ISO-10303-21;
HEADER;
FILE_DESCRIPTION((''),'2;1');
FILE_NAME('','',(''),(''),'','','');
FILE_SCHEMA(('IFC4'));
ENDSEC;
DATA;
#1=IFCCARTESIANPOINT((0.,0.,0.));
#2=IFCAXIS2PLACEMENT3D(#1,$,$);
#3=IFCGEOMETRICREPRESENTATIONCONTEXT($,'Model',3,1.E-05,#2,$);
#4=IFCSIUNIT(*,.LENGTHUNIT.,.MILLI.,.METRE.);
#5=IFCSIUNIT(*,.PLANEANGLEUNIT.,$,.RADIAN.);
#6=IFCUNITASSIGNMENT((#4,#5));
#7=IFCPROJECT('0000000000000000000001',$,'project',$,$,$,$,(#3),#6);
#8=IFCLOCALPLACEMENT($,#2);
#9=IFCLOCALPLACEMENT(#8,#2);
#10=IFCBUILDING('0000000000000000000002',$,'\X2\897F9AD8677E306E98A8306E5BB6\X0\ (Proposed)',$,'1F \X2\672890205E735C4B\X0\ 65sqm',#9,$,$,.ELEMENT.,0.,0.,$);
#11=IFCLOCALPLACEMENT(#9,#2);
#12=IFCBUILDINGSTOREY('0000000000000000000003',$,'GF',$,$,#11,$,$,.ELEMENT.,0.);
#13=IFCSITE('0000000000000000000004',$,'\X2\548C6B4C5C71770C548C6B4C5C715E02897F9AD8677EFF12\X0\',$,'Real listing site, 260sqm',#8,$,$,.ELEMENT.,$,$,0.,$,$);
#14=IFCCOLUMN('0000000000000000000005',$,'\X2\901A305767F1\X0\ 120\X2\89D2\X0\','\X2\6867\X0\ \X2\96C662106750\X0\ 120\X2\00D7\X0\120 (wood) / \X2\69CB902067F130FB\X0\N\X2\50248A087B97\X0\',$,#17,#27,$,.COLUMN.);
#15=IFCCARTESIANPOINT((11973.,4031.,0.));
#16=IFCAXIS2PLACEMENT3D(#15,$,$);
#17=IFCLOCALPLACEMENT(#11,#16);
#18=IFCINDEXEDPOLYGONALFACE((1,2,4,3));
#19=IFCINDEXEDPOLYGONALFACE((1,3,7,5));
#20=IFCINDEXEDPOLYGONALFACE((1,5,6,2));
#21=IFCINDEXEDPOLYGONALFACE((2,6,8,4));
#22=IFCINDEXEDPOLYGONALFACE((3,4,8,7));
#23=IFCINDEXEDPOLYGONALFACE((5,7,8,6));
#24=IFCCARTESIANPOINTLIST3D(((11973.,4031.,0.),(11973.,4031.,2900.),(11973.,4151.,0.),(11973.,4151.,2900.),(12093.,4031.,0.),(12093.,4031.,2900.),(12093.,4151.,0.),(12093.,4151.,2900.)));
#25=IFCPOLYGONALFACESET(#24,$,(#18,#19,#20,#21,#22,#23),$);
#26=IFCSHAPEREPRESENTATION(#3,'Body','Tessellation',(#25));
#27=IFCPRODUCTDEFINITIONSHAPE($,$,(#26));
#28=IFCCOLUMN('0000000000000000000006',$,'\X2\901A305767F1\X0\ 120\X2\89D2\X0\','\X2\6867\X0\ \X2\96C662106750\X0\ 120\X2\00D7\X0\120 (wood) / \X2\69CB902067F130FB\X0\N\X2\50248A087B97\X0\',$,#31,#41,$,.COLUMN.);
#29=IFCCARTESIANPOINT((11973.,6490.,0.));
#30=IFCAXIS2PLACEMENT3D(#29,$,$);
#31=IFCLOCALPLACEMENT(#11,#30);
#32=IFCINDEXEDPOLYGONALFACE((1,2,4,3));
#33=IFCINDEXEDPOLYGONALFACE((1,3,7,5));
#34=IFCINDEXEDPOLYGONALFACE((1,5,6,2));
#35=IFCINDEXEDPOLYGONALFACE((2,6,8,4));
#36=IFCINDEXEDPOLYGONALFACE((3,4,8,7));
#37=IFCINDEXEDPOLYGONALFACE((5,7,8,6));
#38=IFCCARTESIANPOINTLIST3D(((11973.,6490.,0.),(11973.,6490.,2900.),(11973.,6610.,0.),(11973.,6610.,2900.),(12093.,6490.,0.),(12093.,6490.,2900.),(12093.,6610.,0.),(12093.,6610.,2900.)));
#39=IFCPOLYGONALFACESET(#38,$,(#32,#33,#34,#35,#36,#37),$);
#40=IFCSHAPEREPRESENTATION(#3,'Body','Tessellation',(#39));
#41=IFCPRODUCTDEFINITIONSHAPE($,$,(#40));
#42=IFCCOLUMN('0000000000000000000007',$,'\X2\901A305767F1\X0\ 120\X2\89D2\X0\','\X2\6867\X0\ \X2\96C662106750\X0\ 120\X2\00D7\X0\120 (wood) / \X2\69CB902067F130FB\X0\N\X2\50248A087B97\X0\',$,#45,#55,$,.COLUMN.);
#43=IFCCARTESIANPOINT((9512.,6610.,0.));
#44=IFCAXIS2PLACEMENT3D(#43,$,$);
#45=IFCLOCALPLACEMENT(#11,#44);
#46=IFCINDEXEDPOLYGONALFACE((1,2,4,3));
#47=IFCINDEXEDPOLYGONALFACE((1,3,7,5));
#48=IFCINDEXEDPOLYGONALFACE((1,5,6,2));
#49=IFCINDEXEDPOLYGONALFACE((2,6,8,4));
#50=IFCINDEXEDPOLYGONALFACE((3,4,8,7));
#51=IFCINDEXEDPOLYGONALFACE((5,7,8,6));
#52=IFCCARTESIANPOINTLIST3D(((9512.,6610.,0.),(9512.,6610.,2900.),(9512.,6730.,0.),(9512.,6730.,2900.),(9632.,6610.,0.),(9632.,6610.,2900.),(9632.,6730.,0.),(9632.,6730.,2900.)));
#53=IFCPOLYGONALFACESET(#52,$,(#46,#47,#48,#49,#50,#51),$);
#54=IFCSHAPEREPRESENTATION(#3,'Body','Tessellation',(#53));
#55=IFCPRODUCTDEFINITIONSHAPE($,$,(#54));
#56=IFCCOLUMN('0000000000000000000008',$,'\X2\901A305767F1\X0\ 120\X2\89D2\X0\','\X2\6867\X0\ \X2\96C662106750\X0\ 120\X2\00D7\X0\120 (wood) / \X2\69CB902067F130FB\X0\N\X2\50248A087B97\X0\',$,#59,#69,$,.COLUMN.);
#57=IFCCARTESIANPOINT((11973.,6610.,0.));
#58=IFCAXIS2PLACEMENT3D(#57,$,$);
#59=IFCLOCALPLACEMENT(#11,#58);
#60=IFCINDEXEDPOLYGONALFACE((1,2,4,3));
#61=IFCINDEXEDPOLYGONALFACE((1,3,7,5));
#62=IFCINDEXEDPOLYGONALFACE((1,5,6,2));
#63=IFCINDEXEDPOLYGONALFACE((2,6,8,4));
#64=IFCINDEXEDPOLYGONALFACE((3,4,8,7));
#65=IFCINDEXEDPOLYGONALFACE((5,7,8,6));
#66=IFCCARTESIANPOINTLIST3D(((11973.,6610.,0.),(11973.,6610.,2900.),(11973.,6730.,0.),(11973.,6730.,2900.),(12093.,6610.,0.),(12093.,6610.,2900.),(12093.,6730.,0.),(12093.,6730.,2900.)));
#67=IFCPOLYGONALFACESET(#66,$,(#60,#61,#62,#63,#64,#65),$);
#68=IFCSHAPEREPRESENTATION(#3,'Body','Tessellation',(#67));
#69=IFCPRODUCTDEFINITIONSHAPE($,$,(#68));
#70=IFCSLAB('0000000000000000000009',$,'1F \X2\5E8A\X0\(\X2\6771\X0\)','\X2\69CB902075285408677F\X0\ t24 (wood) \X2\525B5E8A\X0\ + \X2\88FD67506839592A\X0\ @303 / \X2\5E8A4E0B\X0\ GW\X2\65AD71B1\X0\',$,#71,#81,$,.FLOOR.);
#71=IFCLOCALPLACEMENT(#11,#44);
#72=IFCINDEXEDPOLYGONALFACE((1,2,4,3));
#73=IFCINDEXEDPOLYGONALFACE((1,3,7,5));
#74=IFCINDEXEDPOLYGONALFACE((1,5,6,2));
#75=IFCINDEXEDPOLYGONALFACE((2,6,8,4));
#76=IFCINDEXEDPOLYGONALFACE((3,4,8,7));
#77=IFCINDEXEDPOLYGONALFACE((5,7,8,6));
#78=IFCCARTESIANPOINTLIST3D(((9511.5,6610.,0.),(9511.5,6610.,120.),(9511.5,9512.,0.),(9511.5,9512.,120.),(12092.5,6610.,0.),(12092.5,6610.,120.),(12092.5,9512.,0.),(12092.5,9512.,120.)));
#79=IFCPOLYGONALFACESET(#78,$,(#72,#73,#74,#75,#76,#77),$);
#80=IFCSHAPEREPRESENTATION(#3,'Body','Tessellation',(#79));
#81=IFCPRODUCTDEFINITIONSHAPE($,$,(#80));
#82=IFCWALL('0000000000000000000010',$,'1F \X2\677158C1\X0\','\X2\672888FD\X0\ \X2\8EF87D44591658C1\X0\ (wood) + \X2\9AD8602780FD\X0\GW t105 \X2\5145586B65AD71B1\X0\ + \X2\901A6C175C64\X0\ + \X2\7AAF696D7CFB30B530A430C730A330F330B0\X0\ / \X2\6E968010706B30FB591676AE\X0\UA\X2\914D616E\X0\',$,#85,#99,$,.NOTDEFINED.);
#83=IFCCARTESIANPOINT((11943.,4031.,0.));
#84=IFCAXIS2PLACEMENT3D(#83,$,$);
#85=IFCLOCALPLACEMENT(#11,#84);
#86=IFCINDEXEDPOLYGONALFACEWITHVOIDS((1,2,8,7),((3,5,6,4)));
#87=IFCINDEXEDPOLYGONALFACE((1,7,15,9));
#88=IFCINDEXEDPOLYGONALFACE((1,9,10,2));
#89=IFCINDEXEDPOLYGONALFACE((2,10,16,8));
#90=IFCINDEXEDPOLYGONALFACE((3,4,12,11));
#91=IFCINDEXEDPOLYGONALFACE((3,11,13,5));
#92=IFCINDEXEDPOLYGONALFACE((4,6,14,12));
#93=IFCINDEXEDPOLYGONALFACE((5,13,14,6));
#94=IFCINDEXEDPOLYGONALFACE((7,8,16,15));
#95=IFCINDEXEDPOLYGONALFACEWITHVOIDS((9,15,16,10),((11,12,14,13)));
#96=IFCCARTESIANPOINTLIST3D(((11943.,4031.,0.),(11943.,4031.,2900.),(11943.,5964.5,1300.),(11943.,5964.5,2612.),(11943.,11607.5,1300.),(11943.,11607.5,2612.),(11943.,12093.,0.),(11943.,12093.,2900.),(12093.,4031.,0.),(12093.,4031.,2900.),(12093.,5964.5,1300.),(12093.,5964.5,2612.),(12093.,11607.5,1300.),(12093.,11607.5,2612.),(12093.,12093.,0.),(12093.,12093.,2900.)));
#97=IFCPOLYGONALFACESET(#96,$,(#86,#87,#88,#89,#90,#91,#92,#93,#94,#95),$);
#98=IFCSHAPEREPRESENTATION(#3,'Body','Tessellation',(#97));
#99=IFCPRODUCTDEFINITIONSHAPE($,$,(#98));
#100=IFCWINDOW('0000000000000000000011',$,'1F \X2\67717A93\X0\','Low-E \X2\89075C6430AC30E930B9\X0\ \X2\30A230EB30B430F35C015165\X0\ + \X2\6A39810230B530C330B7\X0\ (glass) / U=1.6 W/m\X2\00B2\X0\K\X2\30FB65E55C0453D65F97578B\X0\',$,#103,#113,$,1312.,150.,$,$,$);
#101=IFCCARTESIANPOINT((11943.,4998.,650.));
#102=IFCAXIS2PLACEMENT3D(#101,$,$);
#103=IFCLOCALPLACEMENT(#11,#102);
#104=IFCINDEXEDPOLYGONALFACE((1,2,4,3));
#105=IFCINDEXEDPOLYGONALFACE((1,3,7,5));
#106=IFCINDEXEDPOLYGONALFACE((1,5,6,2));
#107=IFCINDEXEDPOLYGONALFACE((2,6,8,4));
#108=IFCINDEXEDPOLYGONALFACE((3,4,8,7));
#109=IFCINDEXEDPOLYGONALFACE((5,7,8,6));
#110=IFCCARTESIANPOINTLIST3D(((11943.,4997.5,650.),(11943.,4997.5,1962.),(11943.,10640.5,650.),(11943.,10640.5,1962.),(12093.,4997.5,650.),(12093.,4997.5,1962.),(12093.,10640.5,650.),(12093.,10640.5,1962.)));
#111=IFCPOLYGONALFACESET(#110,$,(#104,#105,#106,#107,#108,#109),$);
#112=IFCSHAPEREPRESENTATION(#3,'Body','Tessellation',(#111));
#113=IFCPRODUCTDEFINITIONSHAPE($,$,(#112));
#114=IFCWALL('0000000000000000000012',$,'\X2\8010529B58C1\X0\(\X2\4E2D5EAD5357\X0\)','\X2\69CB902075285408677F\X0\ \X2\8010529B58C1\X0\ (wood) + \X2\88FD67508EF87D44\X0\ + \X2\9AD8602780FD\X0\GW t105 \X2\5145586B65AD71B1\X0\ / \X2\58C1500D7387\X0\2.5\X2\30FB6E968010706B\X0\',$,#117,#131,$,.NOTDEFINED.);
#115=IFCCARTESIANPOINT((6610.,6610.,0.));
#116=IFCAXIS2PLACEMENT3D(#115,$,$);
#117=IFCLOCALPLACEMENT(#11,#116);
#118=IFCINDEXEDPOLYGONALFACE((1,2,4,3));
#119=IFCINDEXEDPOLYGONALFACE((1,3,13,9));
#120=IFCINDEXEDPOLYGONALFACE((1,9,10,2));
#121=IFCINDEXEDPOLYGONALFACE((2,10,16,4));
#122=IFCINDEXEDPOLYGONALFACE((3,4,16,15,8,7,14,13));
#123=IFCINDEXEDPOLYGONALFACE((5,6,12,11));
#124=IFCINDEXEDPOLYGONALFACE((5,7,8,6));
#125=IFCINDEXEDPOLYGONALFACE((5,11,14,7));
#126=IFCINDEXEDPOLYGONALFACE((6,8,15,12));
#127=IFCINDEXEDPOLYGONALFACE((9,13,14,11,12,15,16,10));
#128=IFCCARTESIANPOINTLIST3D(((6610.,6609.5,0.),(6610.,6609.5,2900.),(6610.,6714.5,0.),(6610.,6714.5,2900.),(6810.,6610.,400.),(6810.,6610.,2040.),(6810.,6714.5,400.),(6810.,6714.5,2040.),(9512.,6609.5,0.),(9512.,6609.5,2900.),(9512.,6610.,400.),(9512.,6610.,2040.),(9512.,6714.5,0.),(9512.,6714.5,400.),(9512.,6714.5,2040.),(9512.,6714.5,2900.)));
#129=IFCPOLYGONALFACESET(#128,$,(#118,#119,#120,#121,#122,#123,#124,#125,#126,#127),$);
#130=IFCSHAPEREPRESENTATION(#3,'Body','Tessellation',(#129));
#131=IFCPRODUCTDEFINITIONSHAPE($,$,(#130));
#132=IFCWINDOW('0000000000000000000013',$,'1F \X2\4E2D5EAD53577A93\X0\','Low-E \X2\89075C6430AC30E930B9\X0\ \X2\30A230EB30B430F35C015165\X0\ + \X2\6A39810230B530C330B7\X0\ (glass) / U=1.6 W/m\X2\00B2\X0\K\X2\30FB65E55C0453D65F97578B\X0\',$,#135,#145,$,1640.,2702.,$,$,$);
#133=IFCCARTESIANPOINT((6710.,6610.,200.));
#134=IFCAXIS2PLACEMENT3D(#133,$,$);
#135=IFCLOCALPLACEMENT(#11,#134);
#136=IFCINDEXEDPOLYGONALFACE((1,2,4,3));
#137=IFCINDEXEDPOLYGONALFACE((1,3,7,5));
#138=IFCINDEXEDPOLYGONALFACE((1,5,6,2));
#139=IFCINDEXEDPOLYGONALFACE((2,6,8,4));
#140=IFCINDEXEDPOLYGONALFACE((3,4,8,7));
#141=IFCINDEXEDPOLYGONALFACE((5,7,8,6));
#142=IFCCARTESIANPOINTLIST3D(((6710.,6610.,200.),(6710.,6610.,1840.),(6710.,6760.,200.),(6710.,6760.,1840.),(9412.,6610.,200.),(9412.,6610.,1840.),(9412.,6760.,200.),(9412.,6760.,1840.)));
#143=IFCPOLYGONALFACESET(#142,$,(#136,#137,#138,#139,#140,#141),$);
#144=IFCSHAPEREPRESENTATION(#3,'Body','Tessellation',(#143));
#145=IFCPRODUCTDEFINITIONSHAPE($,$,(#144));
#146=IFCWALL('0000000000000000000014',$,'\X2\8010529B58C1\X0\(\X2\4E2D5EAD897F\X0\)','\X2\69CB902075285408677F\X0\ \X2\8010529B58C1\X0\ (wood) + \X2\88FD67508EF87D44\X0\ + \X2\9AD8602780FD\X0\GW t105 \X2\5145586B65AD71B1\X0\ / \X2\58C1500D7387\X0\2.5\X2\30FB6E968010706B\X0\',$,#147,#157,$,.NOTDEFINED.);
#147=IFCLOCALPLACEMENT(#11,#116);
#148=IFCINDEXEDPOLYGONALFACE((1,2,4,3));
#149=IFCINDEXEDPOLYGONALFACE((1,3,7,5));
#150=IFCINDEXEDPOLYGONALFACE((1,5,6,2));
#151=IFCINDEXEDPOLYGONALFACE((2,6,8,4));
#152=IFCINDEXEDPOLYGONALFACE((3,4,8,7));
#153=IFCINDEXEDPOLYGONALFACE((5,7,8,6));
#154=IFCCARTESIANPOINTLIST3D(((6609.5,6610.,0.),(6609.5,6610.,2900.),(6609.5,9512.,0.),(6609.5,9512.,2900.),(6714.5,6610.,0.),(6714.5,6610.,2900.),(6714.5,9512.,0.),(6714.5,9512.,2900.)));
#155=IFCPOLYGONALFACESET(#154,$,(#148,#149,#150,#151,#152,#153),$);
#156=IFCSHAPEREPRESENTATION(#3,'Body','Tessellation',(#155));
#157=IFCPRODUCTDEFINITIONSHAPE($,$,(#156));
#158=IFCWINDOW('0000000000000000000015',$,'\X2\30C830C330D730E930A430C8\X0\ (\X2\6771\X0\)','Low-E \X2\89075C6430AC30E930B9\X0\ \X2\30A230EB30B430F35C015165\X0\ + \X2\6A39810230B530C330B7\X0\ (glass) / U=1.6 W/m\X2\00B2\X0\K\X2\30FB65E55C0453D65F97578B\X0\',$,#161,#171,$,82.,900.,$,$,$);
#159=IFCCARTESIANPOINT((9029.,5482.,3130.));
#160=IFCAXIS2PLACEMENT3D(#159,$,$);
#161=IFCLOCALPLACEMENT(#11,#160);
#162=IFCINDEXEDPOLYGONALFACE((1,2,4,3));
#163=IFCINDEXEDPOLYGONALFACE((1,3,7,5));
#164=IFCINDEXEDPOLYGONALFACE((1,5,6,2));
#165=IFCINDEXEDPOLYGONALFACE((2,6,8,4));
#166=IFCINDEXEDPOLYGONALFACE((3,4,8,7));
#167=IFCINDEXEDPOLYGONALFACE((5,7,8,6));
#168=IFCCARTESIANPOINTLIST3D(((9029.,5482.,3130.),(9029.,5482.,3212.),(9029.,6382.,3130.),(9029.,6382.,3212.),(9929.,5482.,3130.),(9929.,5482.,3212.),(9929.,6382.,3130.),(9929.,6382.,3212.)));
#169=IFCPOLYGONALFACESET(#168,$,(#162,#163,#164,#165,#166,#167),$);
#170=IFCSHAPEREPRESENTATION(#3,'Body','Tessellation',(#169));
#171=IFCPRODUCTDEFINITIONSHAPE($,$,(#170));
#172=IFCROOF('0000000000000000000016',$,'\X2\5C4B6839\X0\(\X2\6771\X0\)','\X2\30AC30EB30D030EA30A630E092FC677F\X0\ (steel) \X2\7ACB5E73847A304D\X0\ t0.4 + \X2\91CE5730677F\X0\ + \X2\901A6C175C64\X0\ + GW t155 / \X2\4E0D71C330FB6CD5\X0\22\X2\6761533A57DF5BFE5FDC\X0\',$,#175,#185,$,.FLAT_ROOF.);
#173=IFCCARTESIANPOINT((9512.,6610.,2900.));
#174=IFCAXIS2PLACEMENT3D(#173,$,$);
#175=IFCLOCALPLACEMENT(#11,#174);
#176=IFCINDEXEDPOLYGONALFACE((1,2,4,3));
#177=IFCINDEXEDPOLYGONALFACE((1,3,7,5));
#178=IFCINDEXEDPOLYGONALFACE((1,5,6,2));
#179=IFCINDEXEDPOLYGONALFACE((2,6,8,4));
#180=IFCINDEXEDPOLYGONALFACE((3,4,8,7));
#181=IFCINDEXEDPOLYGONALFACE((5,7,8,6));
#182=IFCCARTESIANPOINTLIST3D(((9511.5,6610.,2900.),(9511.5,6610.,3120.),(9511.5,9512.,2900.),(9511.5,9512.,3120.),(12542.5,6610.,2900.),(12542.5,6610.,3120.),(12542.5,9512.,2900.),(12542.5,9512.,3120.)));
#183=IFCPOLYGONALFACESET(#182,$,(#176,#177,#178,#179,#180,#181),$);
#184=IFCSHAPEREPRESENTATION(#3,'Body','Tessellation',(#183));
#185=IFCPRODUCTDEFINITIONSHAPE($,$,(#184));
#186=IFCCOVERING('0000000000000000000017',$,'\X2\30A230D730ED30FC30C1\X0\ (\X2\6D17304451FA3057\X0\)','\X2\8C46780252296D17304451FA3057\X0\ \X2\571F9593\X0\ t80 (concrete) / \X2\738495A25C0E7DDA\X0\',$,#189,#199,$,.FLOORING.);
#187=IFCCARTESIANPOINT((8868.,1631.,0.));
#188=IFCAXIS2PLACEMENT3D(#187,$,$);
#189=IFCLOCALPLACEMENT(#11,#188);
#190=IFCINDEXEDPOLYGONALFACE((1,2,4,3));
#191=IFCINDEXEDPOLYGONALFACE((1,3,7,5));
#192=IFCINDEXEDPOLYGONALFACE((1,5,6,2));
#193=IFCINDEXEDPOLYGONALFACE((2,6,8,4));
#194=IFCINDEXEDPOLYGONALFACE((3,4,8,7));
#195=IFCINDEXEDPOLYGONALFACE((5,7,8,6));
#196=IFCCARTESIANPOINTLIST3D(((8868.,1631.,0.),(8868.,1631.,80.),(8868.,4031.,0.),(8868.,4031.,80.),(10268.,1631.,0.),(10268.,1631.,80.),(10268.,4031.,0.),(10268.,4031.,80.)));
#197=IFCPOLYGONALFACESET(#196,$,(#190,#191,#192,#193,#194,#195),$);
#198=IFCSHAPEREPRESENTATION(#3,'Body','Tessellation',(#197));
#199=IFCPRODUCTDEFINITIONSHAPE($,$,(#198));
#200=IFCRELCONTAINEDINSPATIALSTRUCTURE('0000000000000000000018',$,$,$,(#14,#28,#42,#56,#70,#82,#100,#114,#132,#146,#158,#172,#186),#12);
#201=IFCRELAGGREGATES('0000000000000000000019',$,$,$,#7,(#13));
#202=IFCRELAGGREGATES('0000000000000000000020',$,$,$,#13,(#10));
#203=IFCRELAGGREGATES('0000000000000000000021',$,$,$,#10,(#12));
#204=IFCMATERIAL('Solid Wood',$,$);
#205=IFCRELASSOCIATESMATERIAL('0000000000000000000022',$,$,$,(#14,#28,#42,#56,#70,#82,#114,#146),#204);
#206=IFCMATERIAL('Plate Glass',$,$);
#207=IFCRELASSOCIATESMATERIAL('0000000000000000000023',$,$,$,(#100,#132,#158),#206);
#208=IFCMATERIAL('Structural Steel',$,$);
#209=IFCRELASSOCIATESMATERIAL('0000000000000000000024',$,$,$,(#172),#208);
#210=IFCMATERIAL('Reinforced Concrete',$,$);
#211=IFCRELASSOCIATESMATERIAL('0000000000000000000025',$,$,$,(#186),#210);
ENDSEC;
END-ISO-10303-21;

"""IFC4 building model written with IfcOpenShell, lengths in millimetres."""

from ifc_helpers import new_model, si_unit, frame, frame_2d, origin, place, context, project, spatial, rectangle, extrude, material, element, fill, save


model = new_model("IFC4")

# Units and contexts
model_context = context("Model", 3, precision=1e-05, world=origin())
ifc_project = project(units=[si_unit("LENGTHUNIT", "METRE", prefix="MILLI"), si_unit("PLANEANGLEUNIT", "RADIAN")], contexts=[model_context])

# Site, building, storey
site_placement = place(None, origin())
site = spatial("IfcSite", under=ifc_project, at=site_placement, Name="和歌山県和歌山市西高松２", ObjectType="Real listing site, 260sqm", CompositionType="ELEMENT", RefElevation=0.0)
building_placement = place(site_placement, origin())
building = spatial("IfcBuilding", under=site, at=building_placement, Name="西高松の風の家 (Proposed)", ObjectType="1F 木造平屋 65sqm", CompositionType="ELEMENT", ElevationOfRefHeight=0.0, ElevationOfTerrain=0.0)
storey_placement = place(building_placement, origin())
storey = spatial("IfcBuildingStorey", under=building, at=storey_placement, Name="GF", CompositionType="ELEMENT", Elevation=0.0)

# Columns
ifc_material_1 = material(Name="Solid Wood")
column_1_placement = place(storey_placement, frame((11973.0, 4031.0, 0.0)))
element("IfcColumn", 1, at=column_1_placement, inside=storey, material=ifc_material_1, Name="通し柱 120角", Description="桧 集成材 120×120 (wood) / 構造柱・N値計算", PredefinedType="COLUMN", context=model_context, shape_type="SweptSolid", body=[
    extrude(rectangle(XDim=120.0, YDim=120.0, at=frame_2d((60.0, 60.0))), frame((11973.0, 4031.0, 0.0)), (0.0, 0.0, 1.0), 2900.0),
])
column_2_placement = place(storey_placement, frame((11973.0, 6490.0, 0.0)))
element("IfcColumn", 2, at=column_2_placement, inside=storey, material=ifc_material_1, Name="通し柱 120角", Description="桧 集成材 120×120 (wood) / 構造柱・N値計算", PredefinedType="COLUMN", context=model_context, shape_type="SweptSolid", body=[
    extrude(rectangle(XDim=120.0, YDim=120.0, at=frame_2d((60.0, 60.0))), frame((11973.0, 6490.0, 0.0)), (0.0, 0.0, 1.0), 2900.0),
])
column_3_placement = place(storey_placement, frame((9512.0, 6610.0, 0.0)))
element("IfcColumn", 3, at=column_3_placement, inside=storey, material=ifc_material_1, Name="通し柱 120角", Description="桧 集成材 120×120 (wood) / 構造柱・N値計算", PredefinedType="COLUMN", context=model_context, shape_type="SweptSolid", body=[
    extrude(rectangle(XDim=120.0, YDim=120.0, at=frame_2d((60.0, 60.0))), frame((9512.0, 6610.0, 0.0)), (0.0, 0.0, 1.0), 2900.0),
])
column_4_placement = place(storey_placement, frame((11973.0, 6610.0, 0.0)))
element("IfcColumn", 4, at=column_4_placement, inside=storey, material=ifc_material_1, Name="通し柱 120角", Description="桧 集成材 120×120 (wood) / 構造柱・N値計算", PredefinedType="COLUMN", context=model_context, shape_type="SweptSolid", body=[
    extrude(rectangle(XDim=120.0, YDim=120.0, at=frame_2d((60.0, 60.0))), frame((11973.0, 6610.0, 0.0)), (0.0, 0.0, 1.0), 2900.0),
])

# Slab
slab_placement = place(storey_placement, frame((9512.0, 6610.0, 0.0)))
element("IfcSlab", 5, at=slab_placement, inside=storey, material=ifc_material_1, Name="1F 床(東)", Description="構造用合板 t24 (wood) 剛床 + 製材根太 @303 / 床下 GW断熱", PredefinedType="FLOOR", context=model_context, shape_type="SweptSolid", body=[
    extrude(rectangle(XDim=2581.0, YDim=2902.0, at=frame_2d((1290.0, 1451.0))), frame((9512.0, 6610.0, 0.0)), (0.0, 0.0, 1.0), 120.0),
])

# Walls, openings, windows
wall_1_placement = place(storey_placement, frame((11943.0, 4031.0, 0.0)))
wall_1 = element("IfcWall", 6, at=wall_1_placement, inside=storey, material=ifc_material_1, Name="1F 東壁", Description="木製 軸組外壁 (wood) + 高性能GW t105 充填断熱 + 通気層 + 窯業系サイディング / 準耐火・外皮UA配慮", PredefinedType="NOTDEFINED", context=model_context, shape_type="SweptSolid", body=[
    extrude(rectangle(XDim=150.0, YDim=8062.0, at=frame_2d((75.0, 4031.0))), frame((11943.0, 4031.0, 0.0)), (0.0, 0.0, 1.0), 2900.0),
])
opening_1_placement = place(storey_placement, frame((11943.0, 4998.0, 650.0)))
opening_1 = element("IfcOpeningElement", 7, at=opening_1_placement, cuts=wall_1, PredefinedType="NOTDEFINED", context=model_context, shape_type="SweptSolid", body=[
    extrude(rectangle(XDim=150.0, YDim=5643.0, at=frame_2d((75.0, 2821.0))), frame((11943.0, 4998.0, 650.0)), (0.0, 0.0, 1.0), 1312.0),
])
ifc_material_2 = material(Name="Plate Glass")
window_1_placement = place(storey_placement, frame((11943.0, 4998.0, 650.0)))
window_1 = element("IfcWindow", 8, at=window_1_placement, inside=storey, material=ifc_material_2, Name="1F 東窓", Description="Low-E 複層ガラス アルゴン封入 + 樹脂サッシ (glass) / U=1.6 W/m²K・日射取得型", OverallHeight=1312.0, OverallWidth=150.0, context=model_context, shape_type="SweptSolid", body=[
    extrude(rectangle(XDim=150.0, YDim=5643.0, at=frame_2d((75.0, 2821.0))), frame((11943.0, 4998.0, 650.0)), (0.0, 0.0, 1.0), 1312.0),
])
fill(opening_1, window_1)
wall_2_placement = place(storey_placement, frame((6610.0, 6610.0, 0.0)))
wall_2 = element("IfcWall", 9, at=wall_2_placement, inside=storey, material=ifc_material_1, Name="耐力壁(中庭南)", Description="構造用合板 耐力壁 (wood) + 製材軸組 + 高性能GW t105 充填断熱 / 壁倍率2.5・準耐火", PredefinedType="NOTDEFINED", context=model_context, shape_type="SweptSolid", body=[
    extrude(rectangle(XDim=2902.0, YDim=105.0, at=frame_2d((1451.0, 52.0))), frame((6610.0, 6610.0, 0.0)), (0.0, 0.0, 1.0), 2900.0),
])
opening_2_placement = place(storey_placement, frame((6710.0, 6610.0, 200.0)))
opening_2 = element("IfcOpeningElement", 10, at=opening_2_placement, cuts=wall_2, PredefinedType="NOTDEFINED", context=model_context, shape_type="SweptSolid", body=[
    extrude(rectangle(XDim=2702.0, YDim=150.0, at=frame_2d((1351.0, 75.0))), frame((6710.0, 6610.0, 200.0)), (0.0, 0.0, 1.0), 1640.0),
])
window_2_placement = place(storey_placement, frame((6710.0, 6610.0, 200.0)))
window_2 = element("IfcWindow", 11, at=window_2_placement, inside=storey, material=ifc_material_2, Name="1F 中庭南窓", Description="Low-E 複層ガラス アルゴン封入 + 樹脂サッシ (glass) / U=1.6 W/m²K・日射取得型", OverallHeight=1640.0, OverallWidth=2702.0, context=model_context, shape_type="SweptSolid", body=[
    extrude(rectangle(XDim=2702.0, YDim=150.0, at=frame_2d((1351.0, 75.0))), frame((6710.0, 6610.0, 200.0)), (0.0, 0.0, 1.0), 1640.0),
])
fill(opening_2, window_2)

# Wall
wall_3_placement = place(storey_placement, frame((6610.0, 6610.0, 0.0)))
element("IfcWall", 12, at=wall_3_placement, inside=storey, material=ifc_material_1, Name="耐力壁(中庭西)", Description="構造用合板 耐力壁 (wood) + 製材軸組 + 高性能GW t105 充填断熱 / 壁倍率2.5・準耐火", PredefinedType="NOTDEFINED", context=model_context, shape_type="SweptSolid", body=[
    extrude(rectangle(XDim=105.0, YDim=2902.0, at=frame_2d((52.0, 1451.0))), frame((6610.0, 6610.0, 0.0)), (0.0, 0.0, 1.0), 2900.0),
])

# Window
window_3_placement = place(storey_placement, frame((9029.0, 5482.0, 3130.0)))
element("IfcWindow", 13, at=window_3_placement, inside=storey, material=ifc_material_2, Name="トップライト (東)", Description="Low-E 複層ガラス アルゴン封入 + 樹脂サッシ (glass) / U=1.6 W/m²K・日射取得型", OverallHeight=82.0, OverallWidth=900.0, context=model_context, shape_type="SweptSolid", body=[
    extrude(rectangle(XDim=900.0, YDim=900.0, at=frame_2d((450.0, 450.0))), frame((9029.0, 5482.0, 3130.0)), (0.0, 0.0, 1.0), 82.0),
])

# Roof
ifc_material_3 = material(Name="Structural Steel")
roof_placement = place(storey_placement, frame((9512.0, 6610.0, 2900.0)))
element("IfcRoof", 14, at=roof_placement, inside=storey, material=ifc_material_3, Name="屋根(東)", Description="ガルバリウム鋼板 (steel) 立平葺き t0.4 + 野地板 + 通気層 + GW t155 / 不燃・法22条区域対応", PredefinedType="FLAT_ROOF", context=model_context, shape_type="SweptSolid", body=[
    extrude(rectangle(XDim=3031.0, YDim=2902.0, at=frame_2d((1515.0, 1451.0))), frame((9512.0, 6610.0, 2900.0)), (0.0, 0.0, 1.0), 220.0),
])

# Covering
ifc_material_4 = material(Name="Reinforced Concrete")
covering_placement = place(storey_placement, frame((8868.0, 1631.0, 0.0)))
element("IfcCovering", 15, at=covering_placement, inside=storey, material=ifc_material_4, Name="アプローチ (洗い出し)", Description="豆砂利洗い出し 土間 t80 (concrete) / 玄関導線", PredefinedType="FLOORING", context=model_context, shape_type="SweptSolid", body=[
    extrude(rectangle(XDim=1400.0, YDim=2400.0, at=frame_2d((700.0, 1200.0))), frame((8868.0, 1631.0, 0.0)), (0.0, 0.0, 1.0), 80.0),
])

save(model, "model.ifc")
